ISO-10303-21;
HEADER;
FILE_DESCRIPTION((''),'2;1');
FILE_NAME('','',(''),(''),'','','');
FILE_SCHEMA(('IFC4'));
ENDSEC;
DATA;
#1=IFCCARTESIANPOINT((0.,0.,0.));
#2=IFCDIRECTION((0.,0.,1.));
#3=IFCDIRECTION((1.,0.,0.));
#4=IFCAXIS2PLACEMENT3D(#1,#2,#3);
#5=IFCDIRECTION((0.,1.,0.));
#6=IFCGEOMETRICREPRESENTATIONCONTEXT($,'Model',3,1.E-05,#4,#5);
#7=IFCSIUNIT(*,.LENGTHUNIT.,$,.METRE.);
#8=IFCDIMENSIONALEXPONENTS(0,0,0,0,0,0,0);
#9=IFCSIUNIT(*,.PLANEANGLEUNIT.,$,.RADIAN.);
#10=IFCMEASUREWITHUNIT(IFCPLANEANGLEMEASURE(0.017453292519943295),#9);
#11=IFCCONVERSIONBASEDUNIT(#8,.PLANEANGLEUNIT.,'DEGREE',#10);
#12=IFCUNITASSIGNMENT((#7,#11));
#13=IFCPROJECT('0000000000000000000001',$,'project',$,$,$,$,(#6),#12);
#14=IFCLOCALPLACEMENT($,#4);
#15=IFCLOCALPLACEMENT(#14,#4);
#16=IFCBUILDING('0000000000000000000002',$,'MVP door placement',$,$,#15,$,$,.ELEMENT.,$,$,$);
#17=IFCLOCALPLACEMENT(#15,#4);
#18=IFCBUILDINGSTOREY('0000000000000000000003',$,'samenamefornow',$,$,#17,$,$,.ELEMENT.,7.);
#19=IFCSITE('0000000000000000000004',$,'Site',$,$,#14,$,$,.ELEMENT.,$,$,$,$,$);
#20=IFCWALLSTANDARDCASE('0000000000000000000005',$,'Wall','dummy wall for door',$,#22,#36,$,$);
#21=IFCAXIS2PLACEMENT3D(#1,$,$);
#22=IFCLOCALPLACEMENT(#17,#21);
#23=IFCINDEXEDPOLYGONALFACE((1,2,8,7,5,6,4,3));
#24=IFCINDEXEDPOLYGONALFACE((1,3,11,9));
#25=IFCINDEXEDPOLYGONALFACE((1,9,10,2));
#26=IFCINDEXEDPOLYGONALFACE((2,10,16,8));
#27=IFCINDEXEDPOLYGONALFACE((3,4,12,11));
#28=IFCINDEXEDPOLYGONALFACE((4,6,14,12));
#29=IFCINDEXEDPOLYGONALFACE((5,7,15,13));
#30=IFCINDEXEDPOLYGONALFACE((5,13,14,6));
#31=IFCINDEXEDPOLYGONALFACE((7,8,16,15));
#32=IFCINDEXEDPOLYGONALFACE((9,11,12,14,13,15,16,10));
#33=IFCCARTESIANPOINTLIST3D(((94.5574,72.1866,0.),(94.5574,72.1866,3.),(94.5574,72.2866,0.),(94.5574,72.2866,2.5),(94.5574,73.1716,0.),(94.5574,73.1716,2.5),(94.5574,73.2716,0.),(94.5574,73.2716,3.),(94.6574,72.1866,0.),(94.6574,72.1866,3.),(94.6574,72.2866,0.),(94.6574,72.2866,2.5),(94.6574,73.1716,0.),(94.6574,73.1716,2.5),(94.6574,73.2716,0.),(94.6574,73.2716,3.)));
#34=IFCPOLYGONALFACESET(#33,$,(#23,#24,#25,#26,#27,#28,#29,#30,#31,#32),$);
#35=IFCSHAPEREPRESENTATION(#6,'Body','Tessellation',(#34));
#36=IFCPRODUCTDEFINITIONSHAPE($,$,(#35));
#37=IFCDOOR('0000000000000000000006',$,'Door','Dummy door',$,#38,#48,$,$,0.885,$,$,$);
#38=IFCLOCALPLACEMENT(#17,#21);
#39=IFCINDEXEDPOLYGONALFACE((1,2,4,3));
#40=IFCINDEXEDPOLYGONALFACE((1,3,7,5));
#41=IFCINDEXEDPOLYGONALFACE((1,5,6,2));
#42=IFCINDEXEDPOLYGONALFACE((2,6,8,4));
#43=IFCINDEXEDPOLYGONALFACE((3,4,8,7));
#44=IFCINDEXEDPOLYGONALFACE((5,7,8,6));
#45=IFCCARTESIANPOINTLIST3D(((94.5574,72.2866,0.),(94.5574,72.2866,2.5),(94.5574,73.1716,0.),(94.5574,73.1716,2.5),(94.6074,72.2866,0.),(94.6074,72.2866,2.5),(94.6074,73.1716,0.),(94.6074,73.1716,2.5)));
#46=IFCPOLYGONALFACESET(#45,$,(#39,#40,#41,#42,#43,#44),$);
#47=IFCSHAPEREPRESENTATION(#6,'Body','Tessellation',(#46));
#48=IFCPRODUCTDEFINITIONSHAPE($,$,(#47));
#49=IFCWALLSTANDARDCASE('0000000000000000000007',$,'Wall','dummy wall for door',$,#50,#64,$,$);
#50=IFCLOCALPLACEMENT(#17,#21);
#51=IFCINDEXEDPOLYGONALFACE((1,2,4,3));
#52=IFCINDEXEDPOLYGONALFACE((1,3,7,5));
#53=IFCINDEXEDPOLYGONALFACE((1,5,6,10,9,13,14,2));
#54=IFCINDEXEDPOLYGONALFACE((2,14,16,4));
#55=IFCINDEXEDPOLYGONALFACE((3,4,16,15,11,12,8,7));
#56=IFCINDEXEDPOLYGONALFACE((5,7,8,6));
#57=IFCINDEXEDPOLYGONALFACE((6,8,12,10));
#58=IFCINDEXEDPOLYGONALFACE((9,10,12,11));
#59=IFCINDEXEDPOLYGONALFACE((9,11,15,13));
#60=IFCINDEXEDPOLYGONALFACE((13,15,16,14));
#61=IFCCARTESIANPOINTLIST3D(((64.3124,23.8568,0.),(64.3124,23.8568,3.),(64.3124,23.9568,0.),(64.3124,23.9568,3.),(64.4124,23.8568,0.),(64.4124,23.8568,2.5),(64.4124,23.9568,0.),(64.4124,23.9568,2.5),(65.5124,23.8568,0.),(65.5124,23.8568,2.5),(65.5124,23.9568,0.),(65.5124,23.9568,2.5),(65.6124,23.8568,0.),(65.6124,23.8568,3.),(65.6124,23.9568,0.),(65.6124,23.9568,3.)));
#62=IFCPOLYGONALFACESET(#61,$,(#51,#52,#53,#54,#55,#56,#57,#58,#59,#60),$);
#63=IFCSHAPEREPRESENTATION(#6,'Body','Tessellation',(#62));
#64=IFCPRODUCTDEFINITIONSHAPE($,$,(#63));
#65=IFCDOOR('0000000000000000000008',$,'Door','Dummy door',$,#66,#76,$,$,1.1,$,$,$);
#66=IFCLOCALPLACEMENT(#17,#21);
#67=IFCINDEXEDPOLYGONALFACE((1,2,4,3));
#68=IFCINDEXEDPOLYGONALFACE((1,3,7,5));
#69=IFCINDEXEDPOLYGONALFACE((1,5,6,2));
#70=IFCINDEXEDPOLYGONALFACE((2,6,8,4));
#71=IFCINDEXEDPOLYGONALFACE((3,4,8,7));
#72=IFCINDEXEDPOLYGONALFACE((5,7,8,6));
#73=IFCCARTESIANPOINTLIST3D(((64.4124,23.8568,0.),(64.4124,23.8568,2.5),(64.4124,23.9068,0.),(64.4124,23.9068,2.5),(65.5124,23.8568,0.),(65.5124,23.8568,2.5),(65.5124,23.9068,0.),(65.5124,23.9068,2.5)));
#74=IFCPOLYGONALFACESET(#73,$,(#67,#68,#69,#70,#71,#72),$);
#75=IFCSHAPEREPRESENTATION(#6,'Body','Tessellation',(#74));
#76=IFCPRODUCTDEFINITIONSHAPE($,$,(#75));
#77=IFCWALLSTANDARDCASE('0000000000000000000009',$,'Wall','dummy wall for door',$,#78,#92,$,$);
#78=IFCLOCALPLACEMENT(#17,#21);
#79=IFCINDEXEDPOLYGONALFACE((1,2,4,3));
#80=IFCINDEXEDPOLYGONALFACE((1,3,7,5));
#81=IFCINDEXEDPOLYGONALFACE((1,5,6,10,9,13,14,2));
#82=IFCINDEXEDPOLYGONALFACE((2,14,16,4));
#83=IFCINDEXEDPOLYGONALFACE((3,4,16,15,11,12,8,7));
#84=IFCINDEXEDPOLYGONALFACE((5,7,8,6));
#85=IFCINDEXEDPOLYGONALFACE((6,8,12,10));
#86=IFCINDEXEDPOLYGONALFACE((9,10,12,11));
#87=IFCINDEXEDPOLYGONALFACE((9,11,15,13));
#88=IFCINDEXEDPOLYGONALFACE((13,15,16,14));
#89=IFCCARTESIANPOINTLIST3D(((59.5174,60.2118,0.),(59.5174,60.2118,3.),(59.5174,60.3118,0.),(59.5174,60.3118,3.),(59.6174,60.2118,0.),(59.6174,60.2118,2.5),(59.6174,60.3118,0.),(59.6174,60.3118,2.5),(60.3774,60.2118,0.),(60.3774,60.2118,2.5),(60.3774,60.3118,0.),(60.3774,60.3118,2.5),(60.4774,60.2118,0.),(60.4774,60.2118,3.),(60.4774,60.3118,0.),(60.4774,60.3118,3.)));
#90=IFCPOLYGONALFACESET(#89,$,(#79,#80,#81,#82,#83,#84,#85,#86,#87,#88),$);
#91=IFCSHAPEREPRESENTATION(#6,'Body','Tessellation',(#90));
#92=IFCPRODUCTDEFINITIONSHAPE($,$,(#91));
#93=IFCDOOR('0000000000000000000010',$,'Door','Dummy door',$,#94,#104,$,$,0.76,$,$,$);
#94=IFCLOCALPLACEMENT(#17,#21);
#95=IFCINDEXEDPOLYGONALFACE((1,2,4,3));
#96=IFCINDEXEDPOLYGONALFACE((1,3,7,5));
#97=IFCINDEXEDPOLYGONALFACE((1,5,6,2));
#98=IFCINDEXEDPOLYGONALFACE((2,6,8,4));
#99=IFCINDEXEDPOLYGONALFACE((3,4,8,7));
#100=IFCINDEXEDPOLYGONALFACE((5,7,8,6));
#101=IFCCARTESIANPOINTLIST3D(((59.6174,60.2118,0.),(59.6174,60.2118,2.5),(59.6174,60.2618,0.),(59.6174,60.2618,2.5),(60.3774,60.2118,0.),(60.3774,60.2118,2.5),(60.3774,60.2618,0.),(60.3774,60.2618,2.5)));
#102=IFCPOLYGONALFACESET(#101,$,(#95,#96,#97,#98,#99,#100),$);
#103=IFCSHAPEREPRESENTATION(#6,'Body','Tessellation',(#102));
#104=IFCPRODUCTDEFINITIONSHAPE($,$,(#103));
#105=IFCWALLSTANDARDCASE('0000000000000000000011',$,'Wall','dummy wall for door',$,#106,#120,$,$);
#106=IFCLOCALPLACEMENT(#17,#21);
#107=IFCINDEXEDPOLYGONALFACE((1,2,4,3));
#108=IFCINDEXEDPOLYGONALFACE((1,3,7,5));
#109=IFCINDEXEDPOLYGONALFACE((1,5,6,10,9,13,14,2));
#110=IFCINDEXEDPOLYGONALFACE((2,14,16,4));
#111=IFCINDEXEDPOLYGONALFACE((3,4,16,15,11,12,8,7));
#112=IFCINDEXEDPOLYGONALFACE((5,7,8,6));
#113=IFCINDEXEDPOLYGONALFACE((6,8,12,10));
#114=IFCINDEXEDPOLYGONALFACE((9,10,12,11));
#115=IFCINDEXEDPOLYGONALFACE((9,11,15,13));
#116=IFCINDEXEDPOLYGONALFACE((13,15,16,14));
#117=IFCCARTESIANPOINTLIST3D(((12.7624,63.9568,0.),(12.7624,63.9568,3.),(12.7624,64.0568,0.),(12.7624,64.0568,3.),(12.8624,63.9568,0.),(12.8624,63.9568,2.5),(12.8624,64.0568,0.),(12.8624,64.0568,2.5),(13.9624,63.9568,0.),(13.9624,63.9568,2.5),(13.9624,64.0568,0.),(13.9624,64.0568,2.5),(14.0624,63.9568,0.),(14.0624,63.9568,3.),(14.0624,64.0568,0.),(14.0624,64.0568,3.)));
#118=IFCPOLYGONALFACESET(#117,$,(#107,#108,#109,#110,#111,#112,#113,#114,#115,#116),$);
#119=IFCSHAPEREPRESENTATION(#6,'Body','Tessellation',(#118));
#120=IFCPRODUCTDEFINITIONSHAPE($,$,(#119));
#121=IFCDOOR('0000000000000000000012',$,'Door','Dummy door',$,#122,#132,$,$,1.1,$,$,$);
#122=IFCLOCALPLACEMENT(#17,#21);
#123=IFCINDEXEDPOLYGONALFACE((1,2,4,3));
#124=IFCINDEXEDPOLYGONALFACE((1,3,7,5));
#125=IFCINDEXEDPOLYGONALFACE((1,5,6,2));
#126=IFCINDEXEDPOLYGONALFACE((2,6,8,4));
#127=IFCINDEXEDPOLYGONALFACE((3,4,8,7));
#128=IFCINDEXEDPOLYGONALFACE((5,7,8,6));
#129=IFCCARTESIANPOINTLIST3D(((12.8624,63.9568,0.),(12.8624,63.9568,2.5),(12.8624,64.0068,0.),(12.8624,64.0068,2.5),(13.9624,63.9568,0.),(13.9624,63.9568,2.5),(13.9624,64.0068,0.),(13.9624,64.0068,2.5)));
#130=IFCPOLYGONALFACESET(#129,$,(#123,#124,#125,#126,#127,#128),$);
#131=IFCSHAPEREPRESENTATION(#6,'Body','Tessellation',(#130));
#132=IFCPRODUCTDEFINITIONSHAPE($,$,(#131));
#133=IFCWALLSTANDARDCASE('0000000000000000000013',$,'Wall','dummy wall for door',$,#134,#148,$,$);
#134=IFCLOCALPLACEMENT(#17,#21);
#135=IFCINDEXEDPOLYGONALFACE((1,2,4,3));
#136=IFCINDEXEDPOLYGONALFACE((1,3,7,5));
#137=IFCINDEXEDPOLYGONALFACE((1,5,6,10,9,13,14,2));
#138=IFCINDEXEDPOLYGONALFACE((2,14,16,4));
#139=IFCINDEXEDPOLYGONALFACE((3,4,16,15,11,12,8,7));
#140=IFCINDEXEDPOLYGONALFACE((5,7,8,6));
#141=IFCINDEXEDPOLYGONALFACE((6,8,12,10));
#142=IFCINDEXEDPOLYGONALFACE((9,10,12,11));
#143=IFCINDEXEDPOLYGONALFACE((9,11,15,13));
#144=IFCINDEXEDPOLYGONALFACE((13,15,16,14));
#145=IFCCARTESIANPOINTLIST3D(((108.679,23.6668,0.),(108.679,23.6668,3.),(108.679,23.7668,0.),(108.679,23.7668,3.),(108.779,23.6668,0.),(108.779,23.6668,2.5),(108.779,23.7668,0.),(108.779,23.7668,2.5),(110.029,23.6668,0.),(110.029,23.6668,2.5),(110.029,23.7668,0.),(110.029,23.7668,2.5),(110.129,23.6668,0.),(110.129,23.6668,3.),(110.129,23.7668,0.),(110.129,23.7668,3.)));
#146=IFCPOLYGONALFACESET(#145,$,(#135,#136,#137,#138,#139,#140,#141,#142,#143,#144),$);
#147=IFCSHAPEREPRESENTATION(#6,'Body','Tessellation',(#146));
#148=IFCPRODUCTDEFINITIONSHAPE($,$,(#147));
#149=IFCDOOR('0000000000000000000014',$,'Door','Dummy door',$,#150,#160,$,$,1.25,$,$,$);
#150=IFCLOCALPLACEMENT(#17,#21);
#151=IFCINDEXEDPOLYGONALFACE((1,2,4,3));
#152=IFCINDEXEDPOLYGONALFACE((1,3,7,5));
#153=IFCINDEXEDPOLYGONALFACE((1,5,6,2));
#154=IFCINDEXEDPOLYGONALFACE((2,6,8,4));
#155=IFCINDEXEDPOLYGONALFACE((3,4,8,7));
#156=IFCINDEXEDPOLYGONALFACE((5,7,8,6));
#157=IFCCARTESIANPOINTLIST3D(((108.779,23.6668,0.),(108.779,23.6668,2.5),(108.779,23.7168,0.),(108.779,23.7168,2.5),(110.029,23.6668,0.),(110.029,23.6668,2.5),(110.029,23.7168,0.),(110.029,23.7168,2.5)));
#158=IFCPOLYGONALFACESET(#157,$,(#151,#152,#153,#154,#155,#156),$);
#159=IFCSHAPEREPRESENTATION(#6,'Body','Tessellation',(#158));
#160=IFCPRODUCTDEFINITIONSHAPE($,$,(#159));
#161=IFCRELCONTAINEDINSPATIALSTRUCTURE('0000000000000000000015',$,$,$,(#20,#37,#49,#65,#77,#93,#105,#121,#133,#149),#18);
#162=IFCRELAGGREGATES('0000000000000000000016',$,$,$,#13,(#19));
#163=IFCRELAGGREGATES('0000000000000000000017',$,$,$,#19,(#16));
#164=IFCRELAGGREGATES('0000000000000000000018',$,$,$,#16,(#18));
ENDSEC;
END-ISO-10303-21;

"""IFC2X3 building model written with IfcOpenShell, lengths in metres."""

from ifc_helpers import new_model, entity, si_unit, converted_unit, direction, origin_with_axes, place, context, project, spatial, polyline, outline, extrude, element, fill, save


model = new_model("IFC2X3")

# Units and contexts
model_context = context("Model", 3, precision=1e-05, world=origin_with_axes(), true_north=direction((0.0, 1.0, 0.0)))
ifc_project = project(units=[si_unit("LENGTHUNIT", "METRE"), converted_unit("PLANEANGLEUNIT", "DEGREE", entity("IfcPlaneAngleMeasure", 0.017453292519943295), si_unit("PLANEANGLEUNIT", "RADIAN"), dimensions=[0, 0, 0, 0, 0, 0, 0])], contexts=[model_context])

# Site, building, storey
site_placement = place(None, origin_with_axes())
site = spatial("IfcSite", under=ifc_project, at=site_placement, Name="Site", CompositionType="ELEMENT")
building_placement = place(site_placement, origin_with_axes())
building = spatial("IfcBuilding", under=site, at=building_placement, Name="MVP door placement", CompositionType="ELEMENT")
storey_placement = place(building_placement, origin_with_axes())
storey = spatial("IfcBuildingStorey", under=building, at=storey_placement, Name="samenamefornow", CompositionType="ELEMENT", Elevation=7.0)

# Walls, openings, doors
wall_1_placement = place(storey_placement, origin_with_axes())
wall_1 = element("IfcWallStandardCase", 1, at=wall_1_placement, inside=storey, Name="Wall", Description="dummy wall for door", context=model_context, shape_type="SweptSolid", body=[
    extrude(outline(polyline([(94.5574, 73.2716, 0.0), (94.5574, 72.1866, 0.0), (94.6574, 72.1866, 0.0), (94.6574, 73.2716, 0.0), (94.5574, 73.2716, 0.0)])), origin_with_axes(), (0.0, 0.0, 1.0), 3.0),
])
opening_1_placement = place(wall_1_placement, origin_with_axes())
opening_1 = element("IfcOpeningElement", 2, at=opening_1_placement, cuts=wall_1, context=model_context, shape_type="SweptSolid", body=[
    extrude(outline(polyline([(94.5574, 73.1716, 0.0), (94.5574, 72.2866, 0.0), (94.6574, 72.2866, 0.0), (94.6574, 73.1716, 0.0), (94.5574, 73.1716, 0.0)])), origin_with_axes(), (0.0, 0.0, 1.0), 2.5),
])
door_1_placement = place(opening_1_placement, origin_with_axes())
door_1 = element("IfcDoor", 3, at=door_1_placement, inside=storey, Name="Door", Description="Dummy door", OverallWidth=0.885, context=model_context, shape_type="SweptSolid", body=[
    extrude(outline(polyline([(94.5574, 73.1716, 0.0), (94.5574, 72.2866, 0.0), (94.6074, 72.2866, 0.0), (94.6074, 73.1716, 0.0), (94.5574, 73.1716, 0.0)])), origin_with_axes(), (0.0, 0.0, 1.0), 2.5),
])
fill(opening_1, door_1)
wall_2_placement = place(storey_placement, origin_with_axes())
wall_2 = element("IfcWallStandardCase", 4, at=wall_2_placement, inside=storey, Name="Wall", Description="dummy wall for door", context=model_context, shape_type="SweptSolid", body=[
    extrude(outline(polyline([(64.3124, 23.8568, 0.0), (65.6124, 23.8568, 0.0), (65.6124, 23.9568, 0.0), (64.3124, 23.9568, 0.0), (64.3124, 23.8568, 0.0)])), origin_with_axes(), (0.0, 0.0, 1.0), 3.0),
])
opening_2_placement = place(wall_2_placement, origin_with_axes())
opening_2 = element("IfcOpeningElement", 5, at=opening_2_placement, cuts=wall_2, context=model_context, shape_type="SweptSolid", body=[
    extrude(outline(polyline([(64.4124, 23.8568, 0.0), (65.5124, 23.8568, 0.0), (65.5124, 23.9568, 0.0), (64.4124, 23.9568, 0.0), (64.4124, 23.8568, 0.0)])), origin_with_axes(), (0.0, 0.0, 1.0), 2.5),
])
door_2_placement = place(opening_2_placement, origin_with_axes())
door_2 = element("IfcDoor", 6, at=door_2_placement, inside=storey, Name="Door", Description="Dummy door", OverallWidth=1.1, context=model_context, shape_type="SweptSolid", body=[
    extrude(outline(polyline([(64.4124, 23.8568, 0.0), (65.5124, 23.8568, 0.0), (65.5124, 23.9068, 0.0), (64.4124, 23.9068, 0.0), (64.4124, 23.8568, 0.0)])), origin_with_axes(), (0.0, 0.0, 1.0), 2.5),
])
fill(opening_2, door_2)
wall_3_placement = place(storey_placement, origin_with_axes())
wall_3 = element("IfcWallStandardCase", 7, at=wall_3_placement, inside=storey, Name="Wall", Description="dummy wall for door", context=model_context, shape_type="SweptSolid", body=[
    extrude(outline(polyline([(60.4774, 60.2118, 0.0), (59.5174, 60.2118, 0.0), (59.5174, 60.3118, 0.0), (60.4774, 60.3118, 0.0), (60.4774, 60.2118, 0.0)])), origin_with_axes(), (0.0, 0.0, 1.0), 3.0),
])
opening_3_placement = place(wall_3_placement, origin_with_axes())
opening_3 = element("IfcOpeningElement", 8, at=opening_3_placement, cuts=wall_3, context=model_context, shape_type="SweptSolid", body=[
    extrude(outline(polyline([(60.3774, 60.2118, 0.0), (59.6174, 60.2118, 0.0), (59.6174, 60.3118, 0.0), (60.3774, 60.3118, 0.0), (60.3774, 60.2118, 0.0)])), origin_with_axes(), (0.0, 0.0, 1.0), 2.5),
])
door_3_placement = place(opening_3_placement, origin_with_axes())
door_3 = element("IfcDoor", 9, at=door_3_placement, inside=storey, Name="Door", Description="Dummy door", OverallWidth=0.76, context=model_context, shape_type="SweptSolid", body=[
    extrude(outline(polyline([(60.3774, 60.2118, 0.0), (59.6174, 60.2118, 0.0), (59.6174, 60.2618, 0.0), (60.3774, 60.2618, 0.0), (60.3774, 60.2118, 0.0)])), origin_with_axes(), (0.0, 0.0, 1.0), 2.5),
])
fill(opening_3, door_3)
wall_4_placement = place(storey_placement, origin_with_axes())
wall_4 = element("IfcWallStandardCase", 10, at=wall_4_placement, inside=storey, Name="Wall", Description="dummy wall for door", context=model_context, shape_type="SweptSolid", body=[
    extrude(outline(polyline([(14.0624, 63.9568, 0.0), (12.7624, 63.9568, 0.0), (12.7624, 64.0568, 0.0), (14.0624, 64.0568, 0.0), (14.0624, 63.9568, 0.0)])), origin_with_axes(), (0.0, 0.0, 1.0), 3.0),
])
opening_4_placement = place(wall_4_placement, origin_with_axes())
opening_4 = element("IfcOpeningElement", 11, at=opening_4_placement, cuts=wall_4, context=model_context, shape_type="SweptSolid", body=[
    extrude(outline(polyline([(13.9624, 63.9568, 0.0), (12.8624, 63.9568, 0.0), (12.8624, 64.0568, 0.0), (13.9624, 64.0568, 0.0), (13.9624, 63.9568, 0.0)])), origin_with_axes(), (0.0, 0.0, 1.0), 2.5),
])
door_4_placement = place(opening_4_placement, origin_with_axes())
door_4 = element("IfcDoor", 12, at=door_4_placement, inside=storey, Name="Door", Description="Dummy door", OverallWidth=1.1, context=model_context, shape_type="SweptSolid", body=[
    extrude(outline(polyline([(13.9624, 63.9568, 0.0), (12.8624, 63.9568, 0.0), (12.8624, 64.0068, 0.0), (13.9624, 64.0068, 0.0), (13.9624, 63.9568, 0.0)])), origin_with_axes(), (0.0, 0.0, 1.0), 2.5),
])
fill(opening_4, door_4)
wall_5_placement = place(storey_placement, origin_with_axes())
wall_5 = element("IfcWallStandardCase", 13, at=wall_5_placement, inside=storey, Name="Wall", Description="dummy wall for door", context=model_context, shape_type="SweptSolid", body=[
    extrude(outline(polyline([(108.679, 23.6668, 0.0), (110.129, 23.6668, 0.0), (110.129, 23.7668, 0.0), (108.679, 23.7668, 0.0), (108.679, 23.6668, 0.0)])), origin_with_axes(), (0.0, 0.0, 1.0), 3.0),
])
opening_5_placement = place(wall_5_placement, origin_with_axes())
opening_5 = element("IfcOpeningElement", 14, at=opening_5_placement, cuts=wall_5, context=model_context, shape_type="SweptSolid", body=[
    extrude(outline(polyline([(108.779, 23.6668, 0.0), (110.029, 23.6668, 0.0), (110.029, 23.7668, 0.0), (108.779, 23.7668, 0.0), (108.779, 23.6668, 0.0)])), origin_with_axes(), (0.0, 0.0, 1.0), 2.5),
])
door_5_placement = place(opening_5_placement, origin_with_axes())
door_5 = element("IfcDoor", 15, at=door_5_placement, inside=storey, Name="Door", Description="Dummy door", OverallWidth=1.25, context=model_context, shape_type="SweptSolid", body=[
    extrude(outline(polyline([(108.779, 23.6668, 0.0), (110.029, 23.6668, 0.0), (110.029, 23.7168, 0.0), (108.779, 23.7168, 0.0), (108.779, 23.6668, 0.0)])), origin_with_axes(), (0.0, 0.0, 1.0), 2.5),
])
fill(opening_5, door_5)

save(model, "model.ifc")
